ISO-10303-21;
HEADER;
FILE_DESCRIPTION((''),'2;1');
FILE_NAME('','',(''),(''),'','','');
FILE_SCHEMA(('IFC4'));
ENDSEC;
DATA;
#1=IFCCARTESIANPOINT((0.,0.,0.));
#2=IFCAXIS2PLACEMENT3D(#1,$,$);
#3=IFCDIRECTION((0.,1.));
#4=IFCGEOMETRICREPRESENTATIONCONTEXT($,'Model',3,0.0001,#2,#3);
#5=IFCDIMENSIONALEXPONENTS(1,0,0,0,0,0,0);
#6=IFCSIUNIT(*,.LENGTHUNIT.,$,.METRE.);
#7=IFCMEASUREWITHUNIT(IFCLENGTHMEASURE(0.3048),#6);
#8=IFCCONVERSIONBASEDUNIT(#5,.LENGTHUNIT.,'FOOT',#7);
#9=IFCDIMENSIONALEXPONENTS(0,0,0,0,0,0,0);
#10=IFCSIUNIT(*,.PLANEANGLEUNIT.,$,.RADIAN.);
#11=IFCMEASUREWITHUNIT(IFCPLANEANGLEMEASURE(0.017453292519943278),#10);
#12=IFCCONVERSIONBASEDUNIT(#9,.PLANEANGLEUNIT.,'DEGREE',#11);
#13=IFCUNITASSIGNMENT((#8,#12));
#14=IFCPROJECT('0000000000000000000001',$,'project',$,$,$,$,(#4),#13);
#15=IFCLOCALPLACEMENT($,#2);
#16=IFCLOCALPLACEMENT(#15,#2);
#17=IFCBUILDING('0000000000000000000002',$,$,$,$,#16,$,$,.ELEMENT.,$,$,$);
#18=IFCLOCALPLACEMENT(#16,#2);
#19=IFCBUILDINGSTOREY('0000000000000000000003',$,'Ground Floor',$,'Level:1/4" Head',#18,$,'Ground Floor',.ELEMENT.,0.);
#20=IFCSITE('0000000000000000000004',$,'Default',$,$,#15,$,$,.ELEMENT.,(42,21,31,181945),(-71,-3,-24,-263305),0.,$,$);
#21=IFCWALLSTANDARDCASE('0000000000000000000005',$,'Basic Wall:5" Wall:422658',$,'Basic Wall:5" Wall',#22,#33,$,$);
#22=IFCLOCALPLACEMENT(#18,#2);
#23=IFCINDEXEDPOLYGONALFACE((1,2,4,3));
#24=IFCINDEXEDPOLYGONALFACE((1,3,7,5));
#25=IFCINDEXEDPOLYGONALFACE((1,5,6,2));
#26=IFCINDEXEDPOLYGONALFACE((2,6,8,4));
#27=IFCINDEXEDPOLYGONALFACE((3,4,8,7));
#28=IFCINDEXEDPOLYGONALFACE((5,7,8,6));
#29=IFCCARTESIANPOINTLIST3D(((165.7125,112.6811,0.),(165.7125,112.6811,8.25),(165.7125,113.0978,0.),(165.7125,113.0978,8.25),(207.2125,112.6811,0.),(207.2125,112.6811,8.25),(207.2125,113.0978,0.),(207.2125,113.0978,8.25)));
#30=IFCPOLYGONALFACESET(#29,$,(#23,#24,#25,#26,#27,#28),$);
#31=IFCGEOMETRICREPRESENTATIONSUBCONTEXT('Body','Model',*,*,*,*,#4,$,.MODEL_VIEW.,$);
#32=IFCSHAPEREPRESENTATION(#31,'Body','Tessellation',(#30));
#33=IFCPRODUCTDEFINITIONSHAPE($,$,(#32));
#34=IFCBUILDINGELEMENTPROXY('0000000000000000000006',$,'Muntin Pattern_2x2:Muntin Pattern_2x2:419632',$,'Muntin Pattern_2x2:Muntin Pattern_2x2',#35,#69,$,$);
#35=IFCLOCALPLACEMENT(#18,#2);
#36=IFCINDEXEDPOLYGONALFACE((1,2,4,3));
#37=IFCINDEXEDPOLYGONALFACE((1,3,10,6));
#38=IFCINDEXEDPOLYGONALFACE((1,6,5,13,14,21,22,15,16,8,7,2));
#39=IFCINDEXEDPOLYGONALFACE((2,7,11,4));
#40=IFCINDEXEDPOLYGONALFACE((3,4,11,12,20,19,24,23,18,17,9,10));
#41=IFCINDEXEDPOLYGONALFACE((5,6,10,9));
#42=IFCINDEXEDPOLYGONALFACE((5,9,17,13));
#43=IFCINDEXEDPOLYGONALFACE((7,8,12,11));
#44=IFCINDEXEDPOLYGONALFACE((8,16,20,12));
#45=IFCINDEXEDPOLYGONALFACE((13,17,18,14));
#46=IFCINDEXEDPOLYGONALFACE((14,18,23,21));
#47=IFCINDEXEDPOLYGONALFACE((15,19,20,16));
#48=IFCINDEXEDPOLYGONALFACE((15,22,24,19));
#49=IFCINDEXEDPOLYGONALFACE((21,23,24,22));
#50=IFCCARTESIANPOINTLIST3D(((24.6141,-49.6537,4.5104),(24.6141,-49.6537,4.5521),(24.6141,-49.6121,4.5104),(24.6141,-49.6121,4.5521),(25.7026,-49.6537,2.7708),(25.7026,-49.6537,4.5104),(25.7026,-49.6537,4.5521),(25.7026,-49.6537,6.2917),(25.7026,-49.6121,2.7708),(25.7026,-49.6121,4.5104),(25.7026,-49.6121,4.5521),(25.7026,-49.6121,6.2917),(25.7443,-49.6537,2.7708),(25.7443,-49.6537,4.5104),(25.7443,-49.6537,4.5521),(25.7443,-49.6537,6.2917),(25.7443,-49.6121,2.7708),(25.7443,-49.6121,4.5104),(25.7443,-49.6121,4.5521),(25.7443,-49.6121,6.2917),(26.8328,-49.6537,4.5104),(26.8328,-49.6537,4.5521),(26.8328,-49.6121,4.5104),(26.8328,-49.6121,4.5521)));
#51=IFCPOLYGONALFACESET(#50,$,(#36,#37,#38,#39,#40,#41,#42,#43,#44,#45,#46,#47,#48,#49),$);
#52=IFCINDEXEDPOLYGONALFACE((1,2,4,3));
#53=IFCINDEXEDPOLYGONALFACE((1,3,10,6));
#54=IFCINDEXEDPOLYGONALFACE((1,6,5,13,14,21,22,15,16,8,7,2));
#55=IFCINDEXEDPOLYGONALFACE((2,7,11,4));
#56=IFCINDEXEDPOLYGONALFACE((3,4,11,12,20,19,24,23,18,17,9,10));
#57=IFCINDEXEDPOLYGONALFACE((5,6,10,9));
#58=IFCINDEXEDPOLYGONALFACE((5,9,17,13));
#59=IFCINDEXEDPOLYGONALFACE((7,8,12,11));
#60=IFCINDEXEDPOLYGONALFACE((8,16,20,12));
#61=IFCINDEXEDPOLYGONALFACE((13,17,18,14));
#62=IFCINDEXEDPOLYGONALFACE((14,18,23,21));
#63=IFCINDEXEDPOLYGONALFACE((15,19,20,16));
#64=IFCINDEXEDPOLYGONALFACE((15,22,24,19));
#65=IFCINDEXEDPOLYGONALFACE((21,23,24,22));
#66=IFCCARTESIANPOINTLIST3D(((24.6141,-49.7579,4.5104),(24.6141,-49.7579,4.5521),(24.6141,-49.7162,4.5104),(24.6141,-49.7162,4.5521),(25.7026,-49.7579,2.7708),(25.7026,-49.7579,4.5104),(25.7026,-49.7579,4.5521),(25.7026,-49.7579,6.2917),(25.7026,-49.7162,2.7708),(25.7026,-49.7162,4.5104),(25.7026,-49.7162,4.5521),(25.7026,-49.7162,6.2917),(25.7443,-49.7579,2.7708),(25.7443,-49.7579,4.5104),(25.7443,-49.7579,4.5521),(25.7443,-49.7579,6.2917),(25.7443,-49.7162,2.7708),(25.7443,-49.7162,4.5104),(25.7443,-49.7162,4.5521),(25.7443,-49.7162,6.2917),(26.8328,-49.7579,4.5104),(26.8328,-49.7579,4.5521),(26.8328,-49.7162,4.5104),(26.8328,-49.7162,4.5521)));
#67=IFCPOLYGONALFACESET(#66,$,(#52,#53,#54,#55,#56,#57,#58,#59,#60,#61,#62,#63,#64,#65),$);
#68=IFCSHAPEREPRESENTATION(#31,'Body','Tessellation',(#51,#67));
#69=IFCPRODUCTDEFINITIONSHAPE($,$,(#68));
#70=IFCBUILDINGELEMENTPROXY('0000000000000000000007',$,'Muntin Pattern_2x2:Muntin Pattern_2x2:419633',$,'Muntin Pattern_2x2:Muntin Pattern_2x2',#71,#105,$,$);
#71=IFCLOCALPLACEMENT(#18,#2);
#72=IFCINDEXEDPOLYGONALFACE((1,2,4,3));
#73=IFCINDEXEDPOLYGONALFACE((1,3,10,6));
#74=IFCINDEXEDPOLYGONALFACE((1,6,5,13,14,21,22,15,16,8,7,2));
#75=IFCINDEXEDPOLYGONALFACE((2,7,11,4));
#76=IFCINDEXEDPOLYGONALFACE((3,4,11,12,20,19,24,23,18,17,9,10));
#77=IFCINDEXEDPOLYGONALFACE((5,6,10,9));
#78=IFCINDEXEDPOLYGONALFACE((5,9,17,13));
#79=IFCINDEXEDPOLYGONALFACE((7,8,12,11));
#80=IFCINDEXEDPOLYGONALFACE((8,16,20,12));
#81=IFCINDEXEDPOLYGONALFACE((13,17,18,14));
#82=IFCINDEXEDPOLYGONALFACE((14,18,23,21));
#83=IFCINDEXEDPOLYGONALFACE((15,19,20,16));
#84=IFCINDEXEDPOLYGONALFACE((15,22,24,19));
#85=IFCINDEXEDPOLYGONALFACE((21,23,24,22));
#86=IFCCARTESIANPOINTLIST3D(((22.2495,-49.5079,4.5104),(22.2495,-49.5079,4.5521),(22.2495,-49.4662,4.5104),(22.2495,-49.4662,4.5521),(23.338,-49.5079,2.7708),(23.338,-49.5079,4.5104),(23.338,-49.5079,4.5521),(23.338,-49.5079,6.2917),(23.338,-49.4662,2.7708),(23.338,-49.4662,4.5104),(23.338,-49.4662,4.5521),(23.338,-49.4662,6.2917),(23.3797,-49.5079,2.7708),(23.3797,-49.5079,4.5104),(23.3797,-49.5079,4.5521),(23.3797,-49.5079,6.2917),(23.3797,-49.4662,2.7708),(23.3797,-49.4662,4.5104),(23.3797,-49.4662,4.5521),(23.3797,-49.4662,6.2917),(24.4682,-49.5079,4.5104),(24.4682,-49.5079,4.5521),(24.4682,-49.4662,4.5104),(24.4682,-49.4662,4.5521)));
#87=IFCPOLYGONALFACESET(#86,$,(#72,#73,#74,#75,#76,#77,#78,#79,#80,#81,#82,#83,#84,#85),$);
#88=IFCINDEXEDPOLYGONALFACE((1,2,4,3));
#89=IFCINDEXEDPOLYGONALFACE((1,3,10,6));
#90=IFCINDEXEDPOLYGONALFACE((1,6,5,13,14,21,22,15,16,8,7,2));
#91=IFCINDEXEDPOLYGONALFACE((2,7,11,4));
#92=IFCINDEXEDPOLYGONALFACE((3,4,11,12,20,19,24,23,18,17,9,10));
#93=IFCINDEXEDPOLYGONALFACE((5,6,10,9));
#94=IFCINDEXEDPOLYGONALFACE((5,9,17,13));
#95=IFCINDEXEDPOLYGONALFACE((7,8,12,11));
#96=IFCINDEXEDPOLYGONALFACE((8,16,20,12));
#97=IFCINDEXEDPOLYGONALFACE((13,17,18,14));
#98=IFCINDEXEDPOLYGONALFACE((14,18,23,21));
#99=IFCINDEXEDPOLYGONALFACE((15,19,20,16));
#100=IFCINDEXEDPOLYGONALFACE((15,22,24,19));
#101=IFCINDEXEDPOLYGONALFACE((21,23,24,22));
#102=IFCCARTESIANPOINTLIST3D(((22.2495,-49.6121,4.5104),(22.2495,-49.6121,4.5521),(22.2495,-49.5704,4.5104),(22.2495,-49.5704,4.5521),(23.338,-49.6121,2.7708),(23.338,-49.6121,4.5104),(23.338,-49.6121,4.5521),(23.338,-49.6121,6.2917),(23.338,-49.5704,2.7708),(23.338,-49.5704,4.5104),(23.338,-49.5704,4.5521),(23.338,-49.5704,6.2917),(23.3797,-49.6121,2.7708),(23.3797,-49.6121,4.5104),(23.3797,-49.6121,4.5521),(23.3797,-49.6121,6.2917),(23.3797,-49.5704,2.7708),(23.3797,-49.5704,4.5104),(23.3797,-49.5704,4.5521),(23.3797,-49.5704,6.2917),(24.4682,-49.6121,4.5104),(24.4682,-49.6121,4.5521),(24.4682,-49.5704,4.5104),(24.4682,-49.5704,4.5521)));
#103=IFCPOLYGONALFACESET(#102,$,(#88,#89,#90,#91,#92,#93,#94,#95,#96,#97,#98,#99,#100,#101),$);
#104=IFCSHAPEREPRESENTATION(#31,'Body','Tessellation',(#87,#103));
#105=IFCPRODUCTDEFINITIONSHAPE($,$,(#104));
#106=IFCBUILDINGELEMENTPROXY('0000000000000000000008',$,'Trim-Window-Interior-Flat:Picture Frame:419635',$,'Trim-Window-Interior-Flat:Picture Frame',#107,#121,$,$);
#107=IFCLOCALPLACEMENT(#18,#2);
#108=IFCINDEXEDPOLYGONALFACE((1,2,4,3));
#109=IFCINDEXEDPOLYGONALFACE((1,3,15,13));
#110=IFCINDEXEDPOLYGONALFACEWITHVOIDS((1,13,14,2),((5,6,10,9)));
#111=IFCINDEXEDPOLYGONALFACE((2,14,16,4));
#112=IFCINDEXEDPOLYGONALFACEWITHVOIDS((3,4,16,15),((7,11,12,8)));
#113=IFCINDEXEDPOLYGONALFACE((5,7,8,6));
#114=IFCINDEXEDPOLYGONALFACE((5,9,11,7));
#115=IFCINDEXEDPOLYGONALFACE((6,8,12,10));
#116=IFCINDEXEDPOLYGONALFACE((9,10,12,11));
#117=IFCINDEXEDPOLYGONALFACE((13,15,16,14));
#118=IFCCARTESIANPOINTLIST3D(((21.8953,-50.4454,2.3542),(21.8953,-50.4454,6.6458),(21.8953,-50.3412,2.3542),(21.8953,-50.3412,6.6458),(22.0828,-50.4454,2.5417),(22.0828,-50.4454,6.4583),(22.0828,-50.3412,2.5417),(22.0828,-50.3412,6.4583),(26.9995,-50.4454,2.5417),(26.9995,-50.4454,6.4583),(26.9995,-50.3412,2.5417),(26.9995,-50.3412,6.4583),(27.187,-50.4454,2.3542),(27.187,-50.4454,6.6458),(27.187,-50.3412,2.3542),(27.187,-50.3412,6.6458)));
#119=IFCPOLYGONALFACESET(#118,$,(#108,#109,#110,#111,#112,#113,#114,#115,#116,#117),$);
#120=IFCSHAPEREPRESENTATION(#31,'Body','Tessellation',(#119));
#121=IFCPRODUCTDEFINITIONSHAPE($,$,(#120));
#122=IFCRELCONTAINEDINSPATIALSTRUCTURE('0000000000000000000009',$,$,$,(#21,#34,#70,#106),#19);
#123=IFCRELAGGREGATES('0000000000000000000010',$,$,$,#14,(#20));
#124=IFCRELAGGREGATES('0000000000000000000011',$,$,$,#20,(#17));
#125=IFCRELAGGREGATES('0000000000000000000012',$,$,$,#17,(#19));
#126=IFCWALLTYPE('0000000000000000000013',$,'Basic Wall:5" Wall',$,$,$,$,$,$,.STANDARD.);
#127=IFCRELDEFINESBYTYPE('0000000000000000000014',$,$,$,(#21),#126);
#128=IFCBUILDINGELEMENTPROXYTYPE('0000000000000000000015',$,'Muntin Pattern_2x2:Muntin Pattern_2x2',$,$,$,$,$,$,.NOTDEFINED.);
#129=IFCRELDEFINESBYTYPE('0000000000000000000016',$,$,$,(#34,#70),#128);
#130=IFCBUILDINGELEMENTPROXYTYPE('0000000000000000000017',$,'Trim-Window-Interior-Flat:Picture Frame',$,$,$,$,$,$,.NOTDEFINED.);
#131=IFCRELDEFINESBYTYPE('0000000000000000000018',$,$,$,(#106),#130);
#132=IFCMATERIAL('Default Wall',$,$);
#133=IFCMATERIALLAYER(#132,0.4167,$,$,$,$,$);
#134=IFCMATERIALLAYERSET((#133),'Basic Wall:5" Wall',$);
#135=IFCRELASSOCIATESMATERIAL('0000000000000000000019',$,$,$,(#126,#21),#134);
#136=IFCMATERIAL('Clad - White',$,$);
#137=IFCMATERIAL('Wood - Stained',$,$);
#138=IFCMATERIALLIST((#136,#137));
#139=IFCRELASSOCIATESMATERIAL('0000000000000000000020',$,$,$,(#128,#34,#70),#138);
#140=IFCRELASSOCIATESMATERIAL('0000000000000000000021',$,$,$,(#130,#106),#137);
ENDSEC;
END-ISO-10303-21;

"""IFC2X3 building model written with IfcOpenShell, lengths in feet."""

from ifc_helpers import new_model, entity, si_unit, converted_unit, direction, frame, frame_2d, origin, place, context, subcontext, project, spatial, polyline, rectangle, outline, extrude, source, transform, mapped, material, material_list, layer, layer_set, layer_usage, type_object, type_shapes, element, save


model = new_model("IFC2X3")

# Units and contexts
model_context = context("Model", 3, precision=0.0001, world=origin(), true_north=direction((0.0, 1.0)))
body_context = subcontext(model_context, "Body", "Model", "MODEL_VIEW")
ifc_project = project(units=[converted_unit("LENGTHUNIT", "FOOT", entity("IfcLengthMeasure", 0.3048), si_unit("LENGTHUNIT", "METRE"), dimensions=[1, 0, 0, 0, 0, 0, 0]), converted_unit("PLANEANGLEUNIT", "DEGREE", entity("IfcPlaneAngleMeasure", 0.017453292519943278), si_unit("PLANEANGLEUNIT", "RADIAN"), dimensions=[0, 0, 0, 0, 0, 0, 0])], contexts=[model_context])

# Site, building, storey
site_placement = place(None, origin())
site = spatial("IfcSite", under=ifc_project, at=site_placement, Name="Default", CompositionType="ELEMENT", RefLatitude=(42, 21, 31, 181945), RefLongitude=(-71, -3, -24, -263305), RefElevation=0.0)
building_placement = place(site_placement, origin())
building = spatial("IfcBuilding", under=site, at=building_placement, CompositionType="ELEMENT")
storey_placement = place(building_placement, origin())
storey = spatial("IfcBuildingStorey", under=building, at=storey_placement, Name="Ground Floor", ObjectType="Level:1/4\" Head", LongName="Ground Floor", CompositionType="ELEMENT", Elevation=0.0)

# Shared definitions
ifc_material_1 = material(Name="Default Wall")

# Shared definitions
ifc_layer_1 = layer(ifc_material_1, 0.4167)
ifc_layer_set_1 = layer_set([ifc_layer_1], Name="Basic Wall:5\" Wall")
wall_type_1 = type_object("IfcWallType", Name="Basic Wall:5\" Wall", PredefinedType="STANDARD", material=ifc_layer_set_1)

# Wall
ifc_layer_usage_1 = layer_usage(ifc_layer_set_1, "AXIS2", "POSITIVE", -0.2083)
wall_1_placement = place(storey_placement, frame((207.2125, 112.8894, 0.0), z_axis=(0.0, 0.0, 1.0), x_axis=(-1.0, 0.0, 0.0)))
element("IfcWallStandardCase", 1, at=wall_1_placement, inside=storey, type_object=wall_type_1, material=ifc_layer_usage_1, Name="Basic Wall:5\" Wall:422658", ObjectType="Basic Wall:5\" Wall", context=body_context, shape_type="SweptSolid", body=[
    extrude(rectangle(XDim=41.5, YDim=0.4167, at=frame_2d((20.75, 0.0), x_axis=(-1.0, 0.0))), origin(), (0.0, 0.0, 1.0), 8.25),
])

# Building element proxies
ifc_material_2 = material(Name="Clad - White")
ifc_material_3 = material(Name="Wood - Stained")
ifc_material_list_1 = material_list([ifc_material_2, ifc_material_3])
building_element_proxy_type_1 = type_object("IfcBuildingElementProxyType", Name="Muntin Pattern_2x2:Muntin Pattern_2x2", PredefinedType="NOTDEFINED", material=ifc_material_list_1)
shared_shape_1 = source(origin(), body_context, "Body", "SweptSolid", [
    extrude(outline(polyline([(0.0208, -0.0208), (1.7604, -0.0208), (1.7604, 0.0208), (0.0208, 0.0208), (0.0208, 1.1094), (-0.0208, 1.1094), (-0.0208, 0.0208), (-1.7604, 0.0208), (-1.7604, -0.0208), (-0.0208, -0.0208), (-0.0208, -1.1094), (0.0208, -1.1094), (0.0208, -0.0208)])), frame((0.0, 0.0313, 1.7604), z_axis=(0.0, 1.0, 0.0), x_axis=(0.0, 0.0, 1.0)), (0.0, 0.0, 1.0), 0.0417),
    extrude(outline(polyline([(0.0208, -0.0208), (1.7604, -0.0208), (1.7604, 0.0208), (0.0208, 0.0208), (0.0208, 1.1094), (-0.0208, 1.1094), (-0.0208, 0.0208), (-1.7604, 0.0208), (-1.7604, -0.0208), (-0.0208, -0.0208), (-0.0208, -1.1094), (0.0208, -1.1094), (0.0208, -0.0208)])), frame((0.0, -0.0729, 1.7604), z_axis=(0.0, 1.0, 0.0), x_axis=(0.0, 0.0, 1.0)), (0.0, 0.0, 1.0), 0.0417),
])
type_shapes(building_element_proxy_type_1, [shared_shape_1])
for number, where, name in (
    (2, (25.7234, -49.685, 2.7708), "Muntin Pattern_2x2:Muntin Pattern_2x2:419632"),
    (3, (23.3589, -49.5392, 2.7708), "Muntin Pattern_2x2:Muntin Pattern_2x2:419633"),
):
    element("IfcBuildingElementProxy", number, at=place(storey_placement, frame(where)), inside=storey, type_object=building_element_proxy_type_1, material=ifc_material_list_1, Name=name, ObjectType="Muntin Pattern_2x2:Muntin Pattern_2x2", context=body_context, shape_type="MappedRepresentation", body=[
        mapped(shared_shape_1, transform((0.0, 0.0, 0.0), scale=1.0)),
    ])
building_element_proxy_type_2 = type_object("IfcBuildingElementProxyType", Name="Trim-Window-Interior-Flat:Picture Frame", PredefinedType="NOTDEFINED", material=ifc_material_3)
shared_shape_2 = source(origin(), body_context, "Body", "SweptSolid", [
    extrude(outline(polyline([(-2.6458, -2.1458), (2.6458, -2.1458), (2.6458, 2.1458), (-2.6458, 2.1458), (-2.6458, -2.1458)]), holes=[polyline([(-2.4583, -1.9583), (-2.4583, 1.9583), (2.4583, 1.9583), (2.4583, -1.9583), (-2.4583, -1.9583)])]), frame((0.0, -2.0, 0.0), z_axis=(0.0, 0.0, 1.0), x_axis=(-1.0, 0.0, 0.0)), (0.0, 0.0, 1.0), 0.1042),
])
type_shapes(building_element_proxy_type_2, [shared_shape_2])
proxy_1_placement = place(storey_placement, frame((24.5411, -50.3412, 6.5), z_axis=(0.0, -1.0, 0.0), x_axis=(1.0, 0.0, 0.0)))
element("IfcBuildingElementProxy", 4, at=proxy_1_placement, inside=storey, type_object=building_element_proxy_type_2, material=ifc_material_3, Name="Trim-Window-Interior-Flat:Picture Frame:419635", ObjectType="Trim-Window-Interior-Flat:Picture Frame", context=body_context, shape_type="MappedRepresentation", body=[
    mapped(shared_shape_2, transform((0.0, 0.0, 0.0), scale=1.0)),
])

save(model, "model.ifc")
